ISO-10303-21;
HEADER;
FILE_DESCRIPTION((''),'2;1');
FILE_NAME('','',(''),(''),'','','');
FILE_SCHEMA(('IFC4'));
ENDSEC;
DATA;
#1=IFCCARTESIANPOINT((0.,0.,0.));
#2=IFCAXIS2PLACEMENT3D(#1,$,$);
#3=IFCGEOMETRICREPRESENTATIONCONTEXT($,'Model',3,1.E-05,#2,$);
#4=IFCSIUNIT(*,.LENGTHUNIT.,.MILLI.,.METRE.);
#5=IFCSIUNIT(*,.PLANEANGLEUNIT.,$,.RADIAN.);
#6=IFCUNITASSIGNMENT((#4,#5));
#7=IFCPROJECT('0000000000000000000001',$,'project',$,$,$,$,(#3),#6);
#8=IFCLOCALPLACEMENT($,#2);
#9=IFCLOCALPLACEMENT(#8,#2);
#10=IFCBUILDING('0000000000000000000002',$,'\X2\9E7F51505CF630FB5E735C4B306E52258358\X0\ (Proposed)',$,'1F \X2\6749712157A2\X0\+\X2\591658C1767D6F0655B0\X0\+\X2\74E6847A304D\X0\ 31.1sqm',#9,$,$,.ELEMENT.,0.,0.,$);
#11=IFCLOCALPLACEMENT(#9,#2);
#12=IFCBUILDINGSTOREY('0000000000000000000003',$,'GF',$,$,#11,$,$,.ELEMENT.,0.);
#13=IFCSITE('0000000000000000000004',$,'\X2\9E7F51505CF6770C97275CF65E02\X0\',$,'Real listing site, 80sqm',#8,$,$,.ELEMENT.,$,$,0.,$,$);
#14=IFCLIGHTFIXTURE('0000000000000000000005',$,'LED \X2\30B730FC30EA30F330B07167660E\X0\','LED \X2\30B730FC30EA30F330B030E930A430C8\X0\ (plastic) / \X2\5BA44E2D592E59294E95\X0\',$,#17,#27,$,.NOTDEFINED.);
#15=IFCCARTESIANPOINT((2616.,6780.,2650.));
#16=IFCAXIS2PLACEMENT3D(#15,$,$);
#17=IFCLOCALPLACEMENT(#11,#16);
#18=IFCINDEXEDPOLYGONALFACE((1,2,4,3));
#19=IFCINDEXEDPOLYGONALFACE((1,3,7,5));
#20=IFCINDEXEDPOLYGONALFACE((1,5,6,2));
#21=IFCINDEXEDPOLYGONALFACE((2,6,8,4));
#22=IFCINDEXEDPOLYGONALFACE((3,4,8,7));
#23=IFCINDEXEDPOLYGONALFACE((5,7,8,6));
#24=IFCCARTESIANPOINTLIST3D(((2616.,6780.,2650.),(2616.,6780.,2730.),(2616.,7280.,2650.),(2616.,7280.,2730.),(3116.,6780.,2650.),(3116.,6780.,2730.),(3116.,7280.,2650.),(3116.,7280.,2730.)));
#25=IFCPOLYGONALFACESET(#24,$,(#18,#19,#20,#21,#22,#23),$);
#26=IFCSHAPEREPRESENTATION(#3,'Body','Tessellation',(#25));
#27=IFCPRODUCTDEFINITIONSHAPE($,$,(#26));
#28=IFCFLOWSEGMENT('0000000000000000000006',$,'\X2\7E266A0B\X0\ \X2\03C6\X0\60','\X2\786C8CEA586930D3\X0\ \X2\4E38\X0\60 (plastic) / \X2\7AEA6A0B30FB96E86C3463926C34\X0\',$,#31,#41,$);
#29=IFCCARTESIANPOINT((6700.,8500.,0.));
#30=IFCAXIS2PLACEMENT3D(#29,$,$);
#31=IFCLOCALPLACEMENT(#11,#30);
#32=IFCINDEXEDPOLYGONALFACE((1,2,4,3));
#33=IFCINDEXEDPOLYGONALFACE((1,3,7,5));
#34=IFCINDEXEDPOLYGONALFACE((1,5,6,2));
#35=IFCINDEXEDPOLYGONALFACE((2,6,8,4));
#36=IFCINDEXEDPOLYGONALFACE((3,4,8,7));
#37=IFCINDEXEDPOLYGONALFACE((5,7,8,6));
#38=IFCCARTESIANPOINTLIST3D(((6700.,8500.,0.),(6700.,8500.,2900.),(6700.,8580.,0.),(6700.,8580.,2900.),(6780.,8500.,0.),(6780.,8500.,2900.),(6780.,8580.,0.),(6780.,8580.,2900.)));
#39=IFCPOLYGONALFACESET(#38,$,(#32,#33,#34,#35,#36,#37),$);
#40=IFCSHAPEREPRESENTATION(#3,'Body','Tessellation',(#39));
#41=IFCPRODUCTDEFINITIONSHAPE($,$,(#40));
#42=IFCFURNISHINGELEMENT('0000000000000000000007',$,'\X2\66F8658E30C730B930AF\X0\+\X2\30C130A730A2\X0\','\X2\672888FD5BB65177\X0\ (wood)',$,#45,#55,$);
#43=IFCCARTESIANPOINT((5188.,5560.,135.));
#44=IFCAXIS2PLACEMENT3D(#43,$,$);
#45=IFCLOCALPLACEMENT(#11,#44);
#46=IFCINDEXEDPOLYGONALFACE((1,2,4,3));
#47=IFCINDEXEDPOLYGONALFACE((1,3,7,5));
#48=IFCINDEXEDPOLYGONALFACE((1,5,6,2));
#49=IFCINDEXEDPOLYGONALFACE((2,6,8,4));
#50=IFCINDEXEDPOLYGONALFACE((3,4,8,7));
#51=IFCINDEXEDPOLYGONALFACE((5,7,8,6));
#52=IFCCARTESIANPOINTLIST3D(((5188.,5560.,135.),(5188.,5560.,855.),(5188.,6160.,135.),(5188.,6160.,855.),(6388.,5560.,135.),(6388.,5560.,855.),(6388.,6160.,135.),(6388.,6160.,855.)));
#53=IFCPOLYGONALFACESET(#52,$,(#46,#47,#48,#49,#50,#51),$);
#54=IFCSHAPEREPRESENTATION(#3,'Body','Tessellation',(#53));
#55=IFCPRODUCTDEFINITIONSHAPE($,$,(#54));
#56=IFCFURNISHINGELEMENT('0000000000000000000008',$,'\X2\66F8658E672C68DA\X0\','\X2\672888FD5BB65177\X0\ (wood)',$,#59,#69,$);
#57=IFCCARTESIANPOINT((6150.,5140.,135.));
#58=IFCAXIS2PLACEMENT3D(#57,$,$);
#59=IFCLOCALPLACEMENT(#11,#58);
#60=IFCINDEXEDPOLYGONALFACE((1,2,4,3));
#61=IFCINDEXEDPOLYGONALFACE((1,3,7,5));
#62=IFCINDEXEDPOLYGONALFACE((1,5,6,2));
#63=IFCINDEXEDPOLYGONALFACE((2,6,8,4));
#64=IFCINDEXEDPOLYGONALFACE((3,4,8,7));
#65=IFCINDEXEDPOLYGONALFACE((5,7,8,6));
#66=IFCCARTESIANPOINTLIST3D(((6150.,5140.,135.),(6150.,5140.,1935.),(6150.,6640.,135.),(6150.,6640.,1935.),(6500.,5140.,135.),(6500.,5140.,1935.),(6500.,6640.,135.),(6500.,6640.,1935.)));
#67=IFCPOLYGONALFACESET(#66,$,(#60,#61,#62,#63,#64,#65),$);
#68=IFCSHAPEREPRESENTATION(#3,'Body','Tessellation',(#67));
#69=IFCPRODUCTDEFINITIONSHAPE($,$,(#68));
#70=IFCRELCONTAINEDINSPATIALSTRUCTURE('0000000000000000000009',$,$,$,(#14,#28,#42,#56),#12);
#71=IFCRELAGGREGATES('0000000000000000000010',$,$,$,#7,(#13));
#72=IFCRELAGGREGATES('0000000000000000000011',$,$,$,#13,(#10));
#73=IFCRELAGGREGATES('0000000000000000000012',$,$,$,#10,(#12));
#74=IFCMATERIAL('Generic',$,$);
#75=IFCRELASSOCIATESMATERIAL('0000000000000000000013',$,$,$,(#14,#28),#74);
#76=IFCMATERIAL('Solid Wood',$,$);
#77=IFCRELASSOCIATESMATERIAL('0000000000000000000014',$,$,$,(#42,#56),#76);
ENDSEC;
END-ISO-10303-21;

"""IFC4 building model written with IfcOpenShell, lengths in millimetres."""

from ifc_helpers import new_model, si_unit, frame, frame_2d, origin, place, context, project, spatial, rectangle, extrude, material, element, save


model = new_model("IFC4")

# Units and contexts
model_context = context("Model", 3, precision=1e-05, world=origin())
ifc_project = project(units=[si_unit("LENGTHUNIT", "METRE", prefix="MILLI"), si_unit("PLANEANGLEUNIT", "RADIAN")], contexts=[model_context])

# Site, building, storey
site_placement = place(None, origin())
site = spatial("IfcSite", under=ifc_project, at=site_placement, Name="鹿児島県霧島市", ObjectType="Real listing site, 80sqm", CompositionType="ELEMENT", RefElevation=0.0)
building_placement = place(site_placement, origin())
building = spatial("IfcBuilding", under=site, at=building_placement, Name="鹿児島・平屋の別荘 (Proposed)", ObjectType="1F 杉無垢+外壁白漆喰+瓦葺き 31.1sqm", CompositionType="ELEMENT", ElevationOfRefHeight=0.0, ElevationOfTerrain=0.0)
storey_placement = place(building_placement, origin())
storey = spatial("IfcBuildingStorey", under=building, at=storey_placement, Name="GF", CompositionType="ELEMENT", Elevation=0.0)

# Shared definitions
ifc_material_1 = material(Name="Solid Wood")

# Shared definitions
ifc_material_2 = material(Name="Generic")

# Light fixture
light_fixture_1_placement = place(storey_placement, frame((2616.0, 6780.0, 2650.0)))
element("IfcLightFixture", 1, at=light_fixture_1_placement, inside=storey, material=ifc_material_2, Name="LED シーリング照明", Description="LED シーリングライト (plastic) / 室中央天井", PredefinedType="NOTDEFINED", context=model_context, shape_type="SweptSolid", body=[
    extrude(rectangle(XDim=500.0, YDim=500.0, at=frame_2d((250.0, 250.0))), frame((2616.0, 6780.0, 2650.0)), (0.0, 0.0, 1.0), 80.0),
])

# Flow segment
flow_segment_placement = place(storey_placement, frame((6700.0, 8500.0, 0.0)))
element("IfcFlowSegment", 2, at=flow_segment_placement, inside=storey, material=ifc_material_2, Name="縦樋 φ60", Description="硬質塩ビ 丸60 (plastic) / 竪樋・雨水排水", context=model_context, shape_type="SweptSolid", body=[
    extrude(rectangle(XDim=80.0, YDim=80.0, at=frame_2d((40.0, 40.0))), frame((6700.0, 8500.0, 0.0)), (0.0, 0.0, 1.0), 2900.0),
])

# Furnishing elements
furnishing_1_placement = place(storey_placement, frame((5188.0, 5560.0, 135.0)))
element("IfcFurnishingElement", 3, at=furnishing_1_placement, inside=storey, material=ifc_material_1, Name="書斎デスク+チェア", Description="木製家具 (wood)", context=model_context, shape_type="SweptSolid", body=[
    extrude(rectangle(XDim=1200.0, YDim=600.0, at=frame_2d((600.0, 300.0))), frame((5188.0, 5560.0, 135.0)), (0.0, 0.0, 1.0), 720.0),
])
furnishing_2_placement = place(storey_placement, frame((6150.0, 5140.0, 135.0)))
element("IfcFurnishingElement", 4, at=furnishing_2_placement, inside=storey, material=ifc_material_1, Name="書斎本棚", Description="木製家具 (wood)", context=model_context, shape_type="SweptSolid", body=[
    extrude(rectangle(XDim=350.0, YDim=1500.0, at=frame_2d((175.0, 750.0))), frame((6150.0, 5140.0, 135.0)), (0.0, 0.0, 1.0), 1800.0),
])

save(model, "model.ifc")
